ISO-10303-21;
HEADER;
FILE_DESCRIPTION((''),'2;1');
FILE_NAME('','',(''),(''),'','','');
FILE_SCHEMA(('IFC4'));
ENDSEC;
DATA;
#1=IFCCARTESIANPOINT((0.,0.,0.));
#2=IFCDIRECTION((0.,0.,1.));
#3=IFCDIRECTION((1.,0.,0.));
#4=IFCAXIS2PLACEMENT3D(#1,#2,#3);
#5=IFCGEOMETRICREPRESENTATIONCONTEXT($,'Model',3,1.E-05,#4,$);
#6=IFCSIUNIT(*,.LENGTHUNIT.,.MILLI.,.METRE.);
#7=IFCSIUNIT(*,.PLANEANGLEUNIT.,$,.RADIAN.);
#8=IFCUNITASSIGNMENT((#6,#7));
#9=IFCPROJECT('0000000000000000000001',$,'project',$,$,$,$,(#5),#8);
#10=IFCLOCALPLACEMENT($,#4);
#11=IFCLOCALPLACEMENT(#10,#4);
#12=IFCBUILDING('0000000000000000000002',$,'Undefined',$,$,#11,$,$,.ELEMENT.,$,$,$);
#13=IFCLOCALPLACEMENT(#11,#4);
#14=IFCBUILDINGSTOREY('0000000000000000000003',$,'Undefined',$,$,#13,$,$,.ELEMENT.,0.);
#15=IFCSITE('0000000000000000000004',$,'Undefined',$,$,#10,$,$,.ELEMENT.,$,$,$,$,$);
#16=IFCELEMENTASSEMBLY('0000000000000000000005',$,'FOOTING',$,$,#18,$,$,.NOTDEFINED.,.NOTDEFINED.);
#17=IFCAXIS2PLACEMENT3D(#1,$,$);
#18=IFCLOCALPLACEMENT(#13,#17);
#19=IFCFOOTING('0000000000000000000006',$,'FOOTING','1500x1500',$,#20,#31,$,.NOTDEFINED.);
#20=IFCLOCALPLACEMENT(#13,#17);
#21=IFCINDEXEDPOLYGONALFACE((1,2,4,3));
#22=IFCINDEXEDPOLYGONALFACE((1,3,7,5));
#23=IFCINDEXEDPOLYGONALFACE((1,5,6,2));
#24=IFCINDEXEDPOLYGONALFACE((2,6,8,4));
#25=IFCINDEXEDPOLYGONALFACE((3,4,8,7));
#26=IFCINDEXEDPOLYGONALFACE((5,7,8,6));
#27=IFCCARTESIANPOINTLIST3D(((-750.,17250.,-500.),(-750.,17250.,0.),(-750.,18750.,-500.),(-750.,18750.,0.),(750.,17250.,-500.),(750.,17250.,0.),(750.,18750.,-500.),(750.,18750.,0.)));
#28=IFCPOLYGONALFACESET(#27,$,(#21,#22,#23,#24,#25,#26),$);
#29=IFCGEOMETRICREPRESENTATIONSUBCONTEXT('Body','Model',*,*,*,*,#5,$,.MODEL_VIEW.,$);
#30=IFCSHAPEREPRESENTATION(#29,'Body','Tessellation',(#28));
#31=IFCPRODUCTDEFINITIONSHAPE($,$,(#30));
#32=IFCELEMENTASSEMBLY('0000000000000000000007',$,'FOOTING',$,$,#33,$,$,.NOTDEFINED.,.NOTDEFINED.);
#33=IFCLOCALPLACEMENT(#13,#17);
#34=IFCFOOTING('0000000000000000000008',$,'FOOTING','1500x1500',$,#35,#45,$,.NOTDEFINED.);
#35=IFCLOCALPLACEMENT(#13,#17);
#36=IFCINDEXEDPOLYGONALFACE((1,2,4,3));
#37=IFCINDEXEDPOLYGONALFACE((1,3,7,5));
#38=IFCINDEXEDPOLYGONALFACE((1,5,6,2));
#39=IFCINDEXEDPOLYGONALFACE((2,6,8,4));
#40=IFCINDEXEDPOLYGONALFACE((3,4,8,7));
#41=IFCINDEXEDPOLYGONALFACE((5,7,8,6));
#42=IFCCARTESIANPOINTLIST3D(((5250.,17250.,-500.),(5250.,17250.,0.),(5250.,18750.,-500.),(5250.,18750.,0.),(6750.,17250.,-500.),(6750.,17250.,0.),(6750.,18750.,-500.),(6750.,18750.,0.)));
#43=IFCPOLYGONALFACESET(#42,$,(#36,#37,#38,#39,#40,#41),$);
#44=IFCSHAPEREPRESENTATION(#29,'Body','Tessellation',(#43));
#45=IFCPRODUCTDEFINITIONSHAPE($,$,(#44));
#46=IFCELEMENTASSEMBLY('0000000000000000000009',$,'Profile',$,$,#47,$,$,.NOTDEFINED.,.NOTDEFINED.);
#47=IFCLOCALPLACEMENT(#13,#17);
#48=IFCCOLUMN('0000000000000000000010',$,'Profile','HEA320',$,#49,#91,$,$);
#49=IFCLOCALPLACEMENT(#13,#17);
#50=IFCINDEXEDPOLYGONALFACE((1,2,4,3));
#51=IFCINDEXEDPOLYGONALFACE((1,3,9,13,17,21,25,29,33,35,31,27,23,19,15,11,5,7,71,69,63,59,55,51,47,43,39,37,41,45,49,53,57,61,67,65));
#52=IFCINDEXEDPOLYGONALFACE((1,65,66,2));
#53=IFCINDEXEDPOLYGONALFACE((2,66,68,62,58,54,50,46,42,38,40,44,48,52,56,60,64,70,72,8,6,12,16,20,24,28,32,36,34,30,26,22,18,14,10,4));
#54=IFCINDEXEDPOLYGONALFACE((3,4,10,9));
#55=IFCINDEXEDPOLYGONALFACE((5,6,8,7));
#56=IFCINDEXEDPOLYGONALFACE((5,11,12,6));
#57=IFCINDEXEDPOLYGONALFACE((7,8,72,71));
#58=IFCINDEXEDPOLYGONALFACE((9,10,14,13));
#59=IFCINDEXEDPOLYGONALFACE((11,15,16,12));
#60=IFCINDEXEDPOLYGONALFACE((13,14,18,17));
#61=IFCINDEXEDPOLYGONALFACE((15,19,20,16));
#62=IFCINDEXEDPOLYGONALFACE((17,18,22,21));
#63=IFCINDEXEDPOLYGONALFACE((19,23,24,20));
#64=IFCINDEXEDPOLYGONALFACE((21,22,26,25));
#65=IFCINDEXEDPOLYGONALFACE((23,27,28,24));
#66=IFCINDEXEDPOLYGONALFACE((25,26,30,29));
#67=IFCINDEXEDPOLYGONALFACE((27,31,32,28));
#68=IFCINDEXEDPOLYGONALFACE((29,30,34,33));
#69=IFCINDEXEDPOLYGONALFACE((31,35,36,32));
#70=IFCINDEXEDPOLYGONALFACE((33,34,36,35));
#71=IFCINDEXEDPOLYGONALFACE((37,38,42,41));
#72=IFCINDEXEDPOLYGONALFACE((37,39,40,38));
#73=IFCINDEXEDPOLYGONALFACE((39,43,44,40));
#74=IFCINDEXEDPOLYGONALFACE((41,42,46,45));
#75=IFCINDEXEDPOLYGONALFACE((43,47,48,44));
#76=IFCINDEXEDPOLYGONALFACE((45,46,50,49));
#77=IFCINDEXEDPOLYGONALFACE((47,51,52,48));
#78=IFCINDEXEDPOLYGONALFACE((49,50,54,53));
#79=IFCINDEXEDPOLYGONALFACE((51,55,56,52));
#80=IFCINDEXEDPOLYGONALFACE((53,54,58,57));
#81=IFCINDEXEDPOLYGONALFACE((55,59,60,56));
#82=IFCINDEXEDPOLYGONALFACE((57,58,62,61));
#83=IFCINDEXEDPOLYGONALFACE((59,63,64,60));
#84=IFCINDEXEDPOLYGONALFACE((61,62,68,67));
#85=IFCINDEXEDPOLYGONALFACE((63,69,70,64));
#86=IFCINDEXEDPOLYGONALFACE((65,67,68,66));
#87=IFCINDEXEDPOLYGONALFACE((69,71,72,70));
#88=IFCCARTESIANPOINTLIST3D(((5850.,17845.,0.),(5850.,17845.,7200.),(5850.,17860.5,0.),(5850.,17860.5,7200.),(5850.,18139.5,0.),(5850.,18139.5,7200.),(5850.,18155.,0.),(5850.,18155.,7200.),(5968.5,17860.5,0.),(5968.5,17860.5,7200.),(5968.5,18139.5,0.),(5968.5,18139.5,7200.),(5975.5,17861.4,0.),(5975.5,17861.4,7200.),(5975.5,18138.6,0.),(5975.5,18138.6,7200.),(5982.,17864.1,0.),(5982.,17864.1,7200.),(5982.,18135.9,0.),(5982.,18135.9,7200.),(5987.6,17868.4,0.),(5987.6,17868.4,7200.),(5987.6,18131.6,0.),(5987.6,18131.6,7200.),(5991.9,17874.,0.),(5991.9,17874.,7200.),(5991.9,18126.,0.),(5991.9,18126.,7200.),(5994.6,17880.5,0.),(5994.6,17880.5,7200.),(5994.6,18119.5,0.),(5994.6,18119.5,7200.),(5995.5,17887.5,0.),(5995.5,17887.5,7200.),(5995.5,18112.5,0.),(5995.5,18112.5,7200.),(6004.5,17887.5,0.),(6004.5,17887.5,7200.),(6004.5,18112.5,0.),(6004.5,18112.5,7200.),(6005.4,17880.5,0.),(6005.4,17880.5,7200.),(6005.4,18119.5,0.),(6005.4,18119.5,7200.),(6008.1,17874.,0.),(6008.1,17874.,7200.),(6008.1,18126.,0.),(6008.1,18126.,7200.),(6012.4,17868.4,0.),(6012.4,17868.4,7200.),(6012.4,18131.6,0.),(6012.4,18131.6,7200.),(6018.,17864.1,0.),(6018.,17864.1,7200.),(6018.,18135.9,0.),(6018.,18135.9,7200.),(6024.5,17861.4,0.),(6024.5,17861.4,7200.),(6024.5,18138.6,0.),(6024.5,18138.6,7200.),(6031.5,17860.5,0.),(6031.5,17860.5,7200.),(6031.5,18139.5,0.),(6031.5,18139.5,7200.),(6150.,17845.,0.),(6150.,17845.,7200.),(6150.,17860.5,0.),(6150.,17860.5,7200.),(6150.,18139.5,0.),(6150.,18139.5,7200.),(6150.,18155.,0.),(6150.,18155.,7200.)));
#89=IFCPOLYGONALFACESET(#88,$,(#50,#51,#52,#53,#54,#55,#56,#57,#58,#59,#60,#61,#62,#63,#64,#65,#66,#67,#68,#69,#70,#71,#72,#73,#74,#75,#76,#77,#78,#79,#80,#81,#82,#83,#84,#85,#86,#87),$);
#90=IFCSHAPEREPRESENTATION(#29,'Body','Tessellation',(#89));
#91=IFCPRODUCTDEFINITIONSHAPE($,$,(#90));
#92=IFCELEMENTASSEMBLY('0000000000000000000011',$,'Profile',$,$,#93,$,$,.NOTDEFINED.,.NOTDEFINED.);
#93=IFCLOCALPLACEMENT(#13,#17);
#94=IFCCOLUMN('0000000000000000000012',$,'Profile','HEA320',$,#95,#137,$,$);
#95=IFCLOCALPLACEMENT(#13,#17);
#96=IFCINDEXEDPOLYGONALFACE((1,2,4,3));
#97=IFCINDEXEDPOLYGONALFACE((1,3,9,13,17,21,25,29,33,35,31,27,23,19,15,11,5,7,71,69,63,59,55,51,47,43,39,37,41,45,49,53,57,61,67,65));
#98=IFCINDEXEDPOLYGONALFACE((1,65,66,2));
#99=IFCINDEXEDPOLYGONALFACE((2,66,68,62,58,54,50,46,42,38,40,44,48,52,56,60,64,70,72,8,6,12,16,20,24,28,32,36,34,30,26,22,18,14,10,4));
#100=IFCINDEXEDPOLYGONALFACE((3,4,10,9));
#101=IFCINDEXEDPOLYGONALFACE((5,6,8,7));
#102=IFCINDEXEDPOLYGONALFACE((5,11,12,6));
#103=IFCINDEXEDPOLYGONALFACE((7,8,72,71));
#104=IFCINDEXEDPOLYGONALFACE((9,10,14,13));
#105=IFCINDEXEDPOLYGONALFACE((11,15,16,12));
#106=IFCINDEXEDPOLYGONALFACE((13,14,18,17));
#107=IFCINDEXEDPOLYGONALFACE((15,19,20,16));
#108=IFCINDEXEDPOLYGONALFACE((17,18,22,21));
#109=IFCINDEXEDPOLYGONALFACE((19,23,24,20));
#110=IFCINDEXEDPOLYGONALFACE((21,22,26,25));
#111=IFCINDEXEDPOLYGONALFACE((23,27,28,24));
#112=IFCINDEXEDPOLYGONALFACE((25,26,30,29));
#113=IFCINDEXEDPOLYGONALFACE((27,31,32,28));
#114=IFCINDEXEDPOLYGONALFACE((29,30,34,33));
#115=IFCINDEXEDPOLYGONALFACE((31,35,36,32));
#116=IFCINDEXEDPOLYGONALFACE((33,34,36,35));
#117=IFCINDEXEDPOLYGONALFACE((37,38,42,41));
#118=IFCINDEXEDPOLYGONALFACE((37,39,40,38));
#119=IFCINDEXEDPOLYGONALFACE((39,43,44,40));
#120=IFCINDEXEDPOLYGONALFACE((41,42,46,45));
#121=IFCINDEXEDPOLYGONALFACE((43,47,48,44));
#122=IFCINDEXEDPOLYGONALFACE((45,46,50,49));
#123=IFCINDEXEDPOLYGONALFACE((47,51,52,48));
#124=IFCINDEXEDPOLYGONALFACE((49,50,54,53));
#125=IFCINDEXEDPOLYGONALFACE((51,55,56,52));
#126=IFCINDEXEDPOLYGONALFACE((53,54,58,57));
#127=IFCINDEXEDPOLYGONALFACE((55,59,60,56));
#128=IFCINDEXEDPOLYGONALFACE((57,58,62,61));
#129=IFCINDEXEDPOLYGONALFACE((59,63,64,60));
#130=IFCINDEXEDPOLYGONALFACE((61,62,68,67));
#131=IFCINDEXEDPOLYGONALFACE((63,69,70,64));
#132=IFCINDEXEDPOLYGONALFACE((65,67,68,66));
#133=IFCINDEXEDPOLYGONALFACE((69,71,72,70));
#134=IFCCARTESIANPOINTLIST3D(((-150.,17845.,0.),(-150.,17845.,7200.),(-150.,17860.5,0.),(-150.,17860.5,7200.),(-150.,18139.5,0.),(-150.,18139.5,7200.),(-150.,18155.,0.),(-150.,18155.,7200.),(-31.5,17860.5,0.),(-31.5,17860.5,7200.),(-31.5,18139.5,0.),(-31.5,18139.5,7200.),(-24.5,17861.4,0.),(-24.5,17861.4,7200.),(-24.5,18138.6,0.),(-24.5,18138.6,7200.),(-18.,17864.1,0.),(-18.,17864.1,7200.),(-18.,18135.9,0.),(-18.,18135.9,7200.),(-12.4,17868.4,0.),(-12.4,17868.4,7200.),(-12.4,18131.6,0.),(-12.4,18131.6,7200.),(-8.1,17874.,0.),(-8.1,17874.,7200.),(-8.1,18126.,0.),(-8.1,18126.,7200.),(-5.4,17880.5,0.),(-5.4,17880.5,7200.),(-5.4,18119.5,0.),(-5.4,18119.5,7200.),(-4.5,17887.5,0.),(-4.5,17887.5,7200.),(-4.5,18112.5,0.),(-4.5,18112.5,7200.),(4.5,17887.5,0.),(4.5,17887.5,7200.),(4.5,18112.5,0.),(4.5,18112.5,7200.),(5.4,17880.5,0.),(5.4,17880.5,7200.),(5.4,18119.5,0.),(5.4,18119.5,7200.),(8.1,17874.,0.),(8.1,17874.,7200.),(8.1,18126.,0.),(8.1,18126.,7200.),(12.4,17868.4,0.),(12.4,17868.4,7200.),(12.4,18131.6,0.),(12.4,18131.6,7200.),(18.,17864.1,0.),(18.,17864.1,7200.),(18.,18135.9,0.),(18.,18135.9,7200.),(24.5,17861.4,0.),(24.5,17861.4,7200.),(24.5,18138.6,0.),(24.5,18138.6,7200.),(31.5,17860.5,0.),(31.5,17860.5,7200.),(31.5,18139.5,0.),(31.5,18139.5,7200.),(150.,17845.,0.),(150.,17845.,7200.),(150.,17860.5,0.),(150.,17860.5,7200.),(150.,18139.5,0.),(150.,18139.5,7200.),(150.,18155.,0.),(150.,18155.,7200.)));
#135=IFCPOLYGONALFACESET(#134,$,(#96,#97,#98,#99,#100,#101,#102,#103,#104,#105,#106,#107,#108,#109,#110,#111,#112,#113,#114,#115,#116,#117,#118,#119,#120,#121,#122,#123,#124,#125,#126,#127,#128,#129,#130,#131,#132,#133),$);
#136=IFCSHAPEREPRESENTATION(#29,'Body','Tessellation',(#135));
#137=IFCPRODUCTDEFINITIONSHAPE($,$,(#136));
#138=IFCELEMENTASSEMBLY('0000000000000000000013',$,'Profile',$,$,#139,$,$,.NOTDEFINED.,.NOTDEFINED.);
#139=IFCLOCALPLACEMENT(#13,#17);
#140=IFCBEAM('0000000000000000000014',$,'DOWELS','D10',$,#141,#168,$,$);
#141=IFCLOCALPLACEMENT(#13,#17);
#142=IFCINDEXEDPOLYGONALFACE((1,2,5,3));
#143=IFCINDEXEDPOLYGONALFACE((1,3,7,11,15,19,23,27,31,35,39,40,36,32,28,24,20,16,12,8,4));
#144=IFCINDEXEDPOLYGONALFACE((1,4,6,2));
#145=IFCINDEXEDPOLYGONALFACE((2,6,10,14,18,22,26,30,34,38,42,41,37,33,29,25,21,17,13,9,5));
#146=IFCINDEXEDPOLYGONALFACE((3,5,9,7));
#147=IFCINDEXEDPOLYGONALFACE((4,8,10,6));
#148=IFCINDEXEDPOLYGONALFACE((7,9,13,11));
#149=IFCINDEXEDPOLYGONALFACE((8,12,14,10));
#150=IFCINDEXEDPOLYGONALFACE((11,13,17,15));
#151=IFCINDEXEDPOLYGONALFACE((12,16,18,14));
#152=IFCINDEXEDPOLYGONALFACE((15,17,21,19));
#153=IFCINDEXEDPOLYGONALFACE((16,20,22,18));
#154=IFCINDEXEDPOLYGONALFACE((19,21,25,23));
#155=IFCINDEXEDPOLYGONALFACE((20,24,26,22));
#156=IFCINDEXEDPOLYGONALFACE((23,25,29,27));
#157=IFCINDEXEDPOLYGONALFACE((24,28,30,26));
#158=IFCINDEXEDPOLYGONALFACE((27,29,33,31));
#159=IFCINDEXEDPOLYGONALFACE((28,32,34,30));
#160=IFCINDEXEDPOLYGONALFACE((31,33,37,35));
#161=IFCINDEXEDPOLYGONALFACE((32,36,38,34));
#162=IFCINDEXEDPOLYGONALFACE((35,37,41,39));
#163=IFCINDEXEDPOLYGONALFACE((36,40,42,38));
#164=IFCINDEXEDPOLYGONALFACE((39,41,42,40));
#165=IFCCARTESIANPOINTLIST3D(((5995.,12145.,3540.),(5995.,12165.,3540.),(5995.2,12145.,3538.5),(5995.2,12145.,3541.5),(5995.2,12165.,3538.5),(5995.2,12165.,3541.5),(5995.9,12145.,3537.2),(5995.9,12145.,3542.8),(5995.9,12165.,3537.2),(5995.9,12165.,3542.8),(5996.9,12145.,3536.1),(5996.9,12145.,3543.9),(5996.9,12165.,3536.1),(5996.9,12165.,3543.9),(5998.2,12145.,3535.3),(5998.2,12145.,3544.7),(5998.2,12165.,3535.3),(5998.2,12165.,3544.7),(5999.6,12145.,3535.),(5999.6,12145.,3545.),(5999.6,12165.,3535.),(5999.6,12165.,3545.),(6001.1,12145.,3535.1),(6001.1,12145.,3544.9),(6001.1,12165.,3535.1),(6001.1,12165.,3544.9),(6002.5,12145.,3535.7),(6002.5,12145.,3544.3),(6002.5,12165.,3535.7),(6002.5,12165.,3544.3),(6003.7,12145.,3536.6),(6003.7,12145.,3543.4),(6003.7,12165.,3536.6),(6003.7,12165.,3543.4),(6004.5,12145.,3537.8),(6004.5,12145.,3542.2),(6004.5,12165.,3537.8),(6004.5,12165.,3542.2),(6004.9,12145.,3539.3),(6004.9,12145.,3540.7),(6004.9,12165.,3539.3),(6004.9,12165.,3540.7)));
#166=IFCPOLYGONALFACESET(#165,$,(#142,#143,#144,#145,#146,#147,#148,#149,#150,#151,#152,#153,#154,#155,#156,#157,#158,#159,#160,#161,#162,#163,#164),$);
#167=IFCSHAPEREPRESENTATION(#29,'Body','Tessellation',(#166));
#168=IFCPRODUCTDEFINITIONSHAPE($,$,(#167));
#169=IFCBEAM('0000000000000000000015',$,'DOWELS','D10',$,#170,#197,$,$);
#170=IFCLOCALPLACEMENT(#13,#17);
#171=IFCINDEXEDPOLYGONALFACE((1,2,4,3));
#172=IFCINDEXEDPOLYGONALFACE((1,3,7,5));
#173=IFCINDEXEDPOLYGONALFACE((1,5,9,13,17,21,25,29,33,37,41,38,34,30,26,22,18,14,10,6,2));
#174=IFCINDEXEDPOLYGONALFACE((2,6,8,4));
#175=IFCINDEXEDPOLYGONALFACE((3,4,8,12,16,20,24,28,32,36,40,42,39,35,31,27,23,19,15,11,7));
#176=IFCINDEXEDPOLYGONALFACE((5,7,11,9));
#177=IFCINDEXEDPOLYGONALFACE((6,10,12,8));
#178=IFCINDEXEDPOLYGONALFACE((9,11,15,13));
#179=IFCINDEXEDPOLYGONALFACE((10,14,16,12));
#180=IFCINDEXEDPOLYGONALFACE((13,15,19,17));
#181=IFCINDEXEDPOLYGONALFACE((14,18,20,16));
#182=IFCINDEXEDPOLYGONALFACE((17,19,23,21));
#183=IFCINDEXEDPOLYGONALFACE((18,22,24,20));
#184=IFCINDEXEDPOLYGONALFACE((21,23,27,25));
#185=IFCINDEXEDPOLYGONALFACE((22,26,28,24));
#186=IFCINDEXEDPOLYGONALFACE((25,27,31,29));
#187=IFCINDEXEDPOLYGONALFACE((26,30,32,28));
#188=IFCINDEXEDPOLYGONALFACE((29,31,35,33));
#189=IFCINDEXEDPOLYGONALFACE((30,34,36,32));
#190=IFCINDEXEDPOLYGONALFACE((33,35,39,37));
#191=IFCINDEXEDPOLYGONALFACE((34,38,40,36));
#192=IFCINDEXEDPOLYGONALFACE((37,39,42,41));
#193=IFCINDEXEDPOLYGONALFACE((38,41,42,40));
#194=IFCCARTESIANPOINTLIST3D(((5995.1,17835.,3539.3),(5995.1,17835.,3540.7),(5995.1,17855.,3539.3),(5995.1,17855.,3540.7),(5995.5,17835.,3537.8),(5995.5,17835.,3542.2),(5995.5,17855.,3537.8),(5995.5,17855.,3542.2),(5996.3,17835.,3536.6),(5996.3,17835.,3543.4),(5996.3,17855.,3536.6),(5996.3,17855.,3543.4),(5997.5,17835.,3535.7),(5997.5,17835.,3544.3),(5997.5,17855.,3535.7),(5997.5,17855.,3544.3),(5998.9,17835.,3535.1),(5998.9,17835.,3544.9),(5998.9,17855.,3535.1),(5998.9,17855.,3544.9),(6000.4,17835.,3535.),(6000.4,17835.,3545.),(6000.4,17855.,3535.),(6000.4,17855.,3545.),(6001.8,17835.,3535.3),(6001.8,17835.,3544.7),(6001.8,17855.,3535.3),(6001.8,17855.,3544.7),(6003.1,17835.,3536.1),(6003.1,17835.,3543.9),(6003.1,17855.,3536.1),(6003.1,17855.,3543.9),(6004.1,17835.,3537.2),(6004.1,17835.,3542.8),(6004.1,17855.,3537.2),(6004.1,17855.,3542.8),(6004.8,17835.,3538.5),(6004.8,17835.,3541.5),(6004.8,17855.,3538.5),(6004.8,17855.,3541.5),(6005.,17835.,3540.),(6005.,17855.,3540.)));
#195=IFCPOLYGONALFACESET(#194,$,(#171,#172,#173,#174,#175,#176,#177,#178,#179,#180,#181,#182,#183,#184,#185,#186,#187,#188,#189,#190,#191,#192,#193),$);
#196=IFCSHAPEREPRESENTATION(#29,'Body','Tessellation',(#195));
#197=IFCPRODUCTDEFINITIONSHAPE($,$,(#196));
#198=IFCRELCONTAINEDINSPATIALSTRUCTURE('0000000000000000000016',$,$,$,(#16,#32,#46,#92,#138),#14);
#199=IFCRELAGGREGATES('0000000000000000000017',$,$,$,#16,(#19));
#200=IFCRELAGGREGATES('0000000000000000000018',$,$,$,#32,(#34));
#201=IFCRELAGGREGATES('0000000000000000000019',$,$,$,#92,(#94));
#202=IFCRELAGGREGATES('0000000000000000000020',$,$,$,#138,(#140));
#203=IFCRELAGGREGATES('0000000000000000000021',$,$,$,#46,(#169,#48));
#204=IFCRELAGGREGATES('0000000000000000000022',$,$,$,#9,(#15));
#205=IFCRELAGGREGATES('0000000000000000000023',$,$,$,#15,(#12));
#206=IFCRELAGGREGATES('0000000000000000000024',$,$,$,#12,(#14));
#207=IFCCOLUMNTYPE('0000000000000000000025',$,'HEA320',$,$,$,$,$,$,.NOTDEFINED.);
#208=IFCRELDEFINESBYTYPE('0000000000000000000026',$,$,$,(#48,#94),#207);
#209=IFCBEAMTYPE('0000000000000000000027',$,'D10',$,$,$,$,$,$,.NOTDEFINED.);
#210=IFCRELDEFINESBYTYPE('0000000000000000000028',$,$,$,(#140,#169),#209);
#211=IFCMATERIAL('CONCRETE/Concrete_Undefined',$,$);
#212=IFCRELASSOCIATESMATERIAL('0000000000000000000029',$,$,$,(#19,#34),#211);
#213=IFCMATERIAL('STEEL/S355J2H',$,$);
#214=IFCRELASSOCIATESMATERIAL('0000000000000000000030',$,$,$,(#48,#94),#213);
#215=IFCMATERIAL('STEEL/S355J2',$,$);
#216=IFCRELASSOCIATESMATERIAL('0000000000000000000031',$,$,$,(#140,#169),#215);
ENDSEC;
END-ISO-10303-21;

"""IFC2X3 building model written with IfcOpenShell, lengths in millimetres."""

from ifc_helpers import new_model, si_unit, frame, origin_with_axes, origin_2d_with_axis, place, context, subcontext, project, spatial, rectangle, circle, i_section, extrude, material, type_object, element, aggregate, save


model = new_model("IFC2X3")

# Units and contexts
model_context = context("Model", 3, precision=1e-05, world=origin_with_axes())
body_context = subcontext(model_context, "Body", "Model", "MODEL_VIEW")
ifc_project = project(units=[si_unit("LENGTHUNIT", "METRE", prefix="MILLI"), si_unit("PLANEANGLEUNIT", "RADIAN")], contexts=[model_context])

# Site, building, storey
site_placement = place(None, origin_with_axes())
site = spatial("IfcSite", under=ifc_project, at=site_placement, Name="Undefined", CompositionType="ELEMENT")
building_placement = place(site_placement, origin_with_axes())
building = spatial("IfcBuilding", under=site, at=building_placement, Name="Undefined", CompositionType="ELEMENT")
storey_placement = place(building_placement, origin_with_axes())
storey = spatial("IfcBuildingStorey", under=building, at=storey_placement, Name="Undefined", CompositionType="ELEMENT", Elevation=0.0)

# Element assemblies, footings
assembly_1_placement = place(storey_placement, origin_with_axes())
assembly_1 = element("IfcElementAssembly", 1, at=assembly_1_placement, inside=storey, Name="FOOTING", AssemblyPlace="NOTDEFINED", PredefinedType="NOTDEFINED")
ifc_material_1 = material(Name="CONCRETE/Concrete_Undefined")
footing_1_placement = place(assembly_1_placement, frame((0.0, 18000.0, -500.0), z_axis=(0.0, 1.0, 0.0), x_axis=(0.0, 0.0, 1.0)))
footing_1 = element("IfcFooting", 2, at=footing_1_placement, material=ifc_material_1, Name="FOOTING", Description="1500x1500", PredefinedType="NOTDEFINED", context=body_context, shape_type="SweptSolid", body=[
    extrude(rectangle(XDim=1500.0, YDim=1500.0, at=origin_2d_with_axis()), frame((500.0, 0.0, 0.0), z_axis=(-1.0, 0.0, 0.0), x_axis=(0.0, -1.0, 0.0)), (0.0, 0.0, 1.0), 500.0),
])
aggregate(assembly_1, [footing_1])
assembly_2_placement = place(storey_placement, origin_with_axes())
assembly_2 = element("IfcElementAssembly", 3, at=assembly_2_placement, inside=storey, Name="FOOTING", AssemblyPlace="NOTDEFINED", PredefinedType="NOTDEFINED")
footing_2_placement = place(assembly_2_placement, frame((6000.0, 18000.0, -500.0), z_axis=(0.0, 1.0, 0.0), x_axis=(0.0, 0.0, 1.0)))
footing_2 = element("IfcFooting", 4, at=footing_2_placement, material=ifc_material_1, Name="FOOTING", Description="1500x1500", PredefinedType="NOTDEFINED", context=body_context, shape_type="SweptSolid", body=[
    extrude(rectangle(XDim=1500.0, YDim=1500.0, at=origin_2d_with_axis()), frame((500.0, 0.0, 0.0), z_axis=(-1.0, 0.0, 0.0), x_axis=(0.0, -1.0, 0.0)), (0.0, 0.0, 1.0), 500.0),
])
aggregate(assembly_2, [footing_2])

# Element assemblies, columns
assembly_3_placement = place(storey_placement, origin_with_axes())
assembly_3 = element("IfcElementAssembly", 5, at=assembly_3_placement, inside=storey, Name="Profile", AssemblyPlace="NOTDEFINED", PredefinedType="NOTDEFINED")
ifc_material_2 = material(Name="STEEL/S355J2H")
column_type = type_object("IfcColumnType", Name="HEA320", PredefinedType="NOTDEFINED")
column_1_placement = place(assembly_3_placement, frame((6000.0, 18000.0, 0.0), z_axis=(0.0, 0.0, 1.0), x_axis=(0.0, 1.0, 0.0)))
column_1 = element("IfcColumn", 6, at=column_1_placement, type_object=column_type, material=ifc_material_2, Name="Profile", Description="HEA320", context=body_context, shape_type="SweptSolid", body=[
    extrude(i_section(OverallWidth=300.0, OverallDepth=310.0, WebThickness=9.0, FlangeThickness=15.5, FilletRadius=27.0, at=origin_2d_with_axis()), frame((0.0, 0.0, 7200.0), z_axis=(0.0, 0.0, -1.0), x_axis=(0.0, 1.0, 0.0)), (0.0, 0.0, 1.0), 7200.0),
])
assembly_4_placement = place(storey_placement, origin_with_axes())
assembly_4 = element("IfcElementAssembly", 7, at=assembly_4_placement, inside=storey, Name="Profile", AssemblyPlace="NOTDEFINED", PredefinedType="NOTDEFINED")
column_2_placement = place(assembly_4_placement, frame((0.0, 18000.0, 0.0), z_axis=(0.0, 0.0, 1.0), x_axis=(0.0, 1.0, 0.0)))
column_2 = element("IfcColumn", 8, at=column_2_placement, type_object=column_type, material=ifc_material_2, Name="Profile", Description="HEA320", context=body_context, shape_type="SweptSolid", body=[
    extrude(i_section(OverallWidth=300.0, OverallDepth=310.0, WebThickness=9.0, FlangeThickness=15.5, FilletRadius=27.0, at=origin_2d_with_axis()), frame((0.0, 0.0, 7200.0), z_axis=(0.0, 0.0, -1.0), x_axis=(0.0, 1.0, 0.0)), (0.0, 0.0, 1.0), 7200.0),
])

# Element assembly, beam
assembly_5_placement = place(storey_placement, origin_with_axes())
assembly_5 = element("IfcElementAssembly", 9, at=assembly_5_placement, inside=storey, Name="Profile", AssemblyPlace="NOTDEFINED", PredefinedType="NOTDEFINED")
ifc_material_3 = material(Name="STEEL/S355J2")
beam_type_1 = type_object("IfcBeamType", Name="D10", PredefinedType="NOTDEFINED")
beam_1_placement = place(assembly_5_placement, frame((6000.0, 12165.0, 3540.0), z_axis=(0.0, 0.0, 1.0), x_axis=(0.0, -1.0, 0.0)))
beam_1 = element("IfcBeam", 10, at=beam_1_placement, type_object=beam_type_1, material=ifc_material_3, Name="DOWELS", Description="D10", context=body_context, shape_type="SweptSolid", body=[
    extrude(circle(Radius=5.0, at=origin_2d_with_axis()), frame((20.0, 0.0, 0.0), z_axis=(-1.0, 0.0, 0.0), x_axis=(0.0, -1.0, 0.0)), (0.0, 0.0, 1.0), 20.0),
])

# Beam
beam_2_placement = place(assembly_3_placement, frame((6000.0, 17835.0, 3540.0), z_axis=(0.0, 0.0, 1.0), x_axis=(0.0, 1.0, 0.0)))
beam_2 = element("IfcBeam", 11, at=beam_2_placement, type_object=beam_type_1, material=ifc_material_3, Name="DOWELS", Description="D10", context=body_context, shape_type="SweptSolid", body=[
    extrude(circle(Radius=5.0, at=origin_2d_with_axis()), frame((20.0, 0.0, 0.0), z_axis=(-1.0, 0.0, 0.0), x_axis=(0.0, -1.0, 0.0)), (0.0, 0.0, 1.0), 20.0),
])
aggregate(assembly_4, [column_2])

aggregate(assembly_5, [beam_1])
aggregate(assembly_3, [beam_2, column_1])

save(model, "model.ifc")
